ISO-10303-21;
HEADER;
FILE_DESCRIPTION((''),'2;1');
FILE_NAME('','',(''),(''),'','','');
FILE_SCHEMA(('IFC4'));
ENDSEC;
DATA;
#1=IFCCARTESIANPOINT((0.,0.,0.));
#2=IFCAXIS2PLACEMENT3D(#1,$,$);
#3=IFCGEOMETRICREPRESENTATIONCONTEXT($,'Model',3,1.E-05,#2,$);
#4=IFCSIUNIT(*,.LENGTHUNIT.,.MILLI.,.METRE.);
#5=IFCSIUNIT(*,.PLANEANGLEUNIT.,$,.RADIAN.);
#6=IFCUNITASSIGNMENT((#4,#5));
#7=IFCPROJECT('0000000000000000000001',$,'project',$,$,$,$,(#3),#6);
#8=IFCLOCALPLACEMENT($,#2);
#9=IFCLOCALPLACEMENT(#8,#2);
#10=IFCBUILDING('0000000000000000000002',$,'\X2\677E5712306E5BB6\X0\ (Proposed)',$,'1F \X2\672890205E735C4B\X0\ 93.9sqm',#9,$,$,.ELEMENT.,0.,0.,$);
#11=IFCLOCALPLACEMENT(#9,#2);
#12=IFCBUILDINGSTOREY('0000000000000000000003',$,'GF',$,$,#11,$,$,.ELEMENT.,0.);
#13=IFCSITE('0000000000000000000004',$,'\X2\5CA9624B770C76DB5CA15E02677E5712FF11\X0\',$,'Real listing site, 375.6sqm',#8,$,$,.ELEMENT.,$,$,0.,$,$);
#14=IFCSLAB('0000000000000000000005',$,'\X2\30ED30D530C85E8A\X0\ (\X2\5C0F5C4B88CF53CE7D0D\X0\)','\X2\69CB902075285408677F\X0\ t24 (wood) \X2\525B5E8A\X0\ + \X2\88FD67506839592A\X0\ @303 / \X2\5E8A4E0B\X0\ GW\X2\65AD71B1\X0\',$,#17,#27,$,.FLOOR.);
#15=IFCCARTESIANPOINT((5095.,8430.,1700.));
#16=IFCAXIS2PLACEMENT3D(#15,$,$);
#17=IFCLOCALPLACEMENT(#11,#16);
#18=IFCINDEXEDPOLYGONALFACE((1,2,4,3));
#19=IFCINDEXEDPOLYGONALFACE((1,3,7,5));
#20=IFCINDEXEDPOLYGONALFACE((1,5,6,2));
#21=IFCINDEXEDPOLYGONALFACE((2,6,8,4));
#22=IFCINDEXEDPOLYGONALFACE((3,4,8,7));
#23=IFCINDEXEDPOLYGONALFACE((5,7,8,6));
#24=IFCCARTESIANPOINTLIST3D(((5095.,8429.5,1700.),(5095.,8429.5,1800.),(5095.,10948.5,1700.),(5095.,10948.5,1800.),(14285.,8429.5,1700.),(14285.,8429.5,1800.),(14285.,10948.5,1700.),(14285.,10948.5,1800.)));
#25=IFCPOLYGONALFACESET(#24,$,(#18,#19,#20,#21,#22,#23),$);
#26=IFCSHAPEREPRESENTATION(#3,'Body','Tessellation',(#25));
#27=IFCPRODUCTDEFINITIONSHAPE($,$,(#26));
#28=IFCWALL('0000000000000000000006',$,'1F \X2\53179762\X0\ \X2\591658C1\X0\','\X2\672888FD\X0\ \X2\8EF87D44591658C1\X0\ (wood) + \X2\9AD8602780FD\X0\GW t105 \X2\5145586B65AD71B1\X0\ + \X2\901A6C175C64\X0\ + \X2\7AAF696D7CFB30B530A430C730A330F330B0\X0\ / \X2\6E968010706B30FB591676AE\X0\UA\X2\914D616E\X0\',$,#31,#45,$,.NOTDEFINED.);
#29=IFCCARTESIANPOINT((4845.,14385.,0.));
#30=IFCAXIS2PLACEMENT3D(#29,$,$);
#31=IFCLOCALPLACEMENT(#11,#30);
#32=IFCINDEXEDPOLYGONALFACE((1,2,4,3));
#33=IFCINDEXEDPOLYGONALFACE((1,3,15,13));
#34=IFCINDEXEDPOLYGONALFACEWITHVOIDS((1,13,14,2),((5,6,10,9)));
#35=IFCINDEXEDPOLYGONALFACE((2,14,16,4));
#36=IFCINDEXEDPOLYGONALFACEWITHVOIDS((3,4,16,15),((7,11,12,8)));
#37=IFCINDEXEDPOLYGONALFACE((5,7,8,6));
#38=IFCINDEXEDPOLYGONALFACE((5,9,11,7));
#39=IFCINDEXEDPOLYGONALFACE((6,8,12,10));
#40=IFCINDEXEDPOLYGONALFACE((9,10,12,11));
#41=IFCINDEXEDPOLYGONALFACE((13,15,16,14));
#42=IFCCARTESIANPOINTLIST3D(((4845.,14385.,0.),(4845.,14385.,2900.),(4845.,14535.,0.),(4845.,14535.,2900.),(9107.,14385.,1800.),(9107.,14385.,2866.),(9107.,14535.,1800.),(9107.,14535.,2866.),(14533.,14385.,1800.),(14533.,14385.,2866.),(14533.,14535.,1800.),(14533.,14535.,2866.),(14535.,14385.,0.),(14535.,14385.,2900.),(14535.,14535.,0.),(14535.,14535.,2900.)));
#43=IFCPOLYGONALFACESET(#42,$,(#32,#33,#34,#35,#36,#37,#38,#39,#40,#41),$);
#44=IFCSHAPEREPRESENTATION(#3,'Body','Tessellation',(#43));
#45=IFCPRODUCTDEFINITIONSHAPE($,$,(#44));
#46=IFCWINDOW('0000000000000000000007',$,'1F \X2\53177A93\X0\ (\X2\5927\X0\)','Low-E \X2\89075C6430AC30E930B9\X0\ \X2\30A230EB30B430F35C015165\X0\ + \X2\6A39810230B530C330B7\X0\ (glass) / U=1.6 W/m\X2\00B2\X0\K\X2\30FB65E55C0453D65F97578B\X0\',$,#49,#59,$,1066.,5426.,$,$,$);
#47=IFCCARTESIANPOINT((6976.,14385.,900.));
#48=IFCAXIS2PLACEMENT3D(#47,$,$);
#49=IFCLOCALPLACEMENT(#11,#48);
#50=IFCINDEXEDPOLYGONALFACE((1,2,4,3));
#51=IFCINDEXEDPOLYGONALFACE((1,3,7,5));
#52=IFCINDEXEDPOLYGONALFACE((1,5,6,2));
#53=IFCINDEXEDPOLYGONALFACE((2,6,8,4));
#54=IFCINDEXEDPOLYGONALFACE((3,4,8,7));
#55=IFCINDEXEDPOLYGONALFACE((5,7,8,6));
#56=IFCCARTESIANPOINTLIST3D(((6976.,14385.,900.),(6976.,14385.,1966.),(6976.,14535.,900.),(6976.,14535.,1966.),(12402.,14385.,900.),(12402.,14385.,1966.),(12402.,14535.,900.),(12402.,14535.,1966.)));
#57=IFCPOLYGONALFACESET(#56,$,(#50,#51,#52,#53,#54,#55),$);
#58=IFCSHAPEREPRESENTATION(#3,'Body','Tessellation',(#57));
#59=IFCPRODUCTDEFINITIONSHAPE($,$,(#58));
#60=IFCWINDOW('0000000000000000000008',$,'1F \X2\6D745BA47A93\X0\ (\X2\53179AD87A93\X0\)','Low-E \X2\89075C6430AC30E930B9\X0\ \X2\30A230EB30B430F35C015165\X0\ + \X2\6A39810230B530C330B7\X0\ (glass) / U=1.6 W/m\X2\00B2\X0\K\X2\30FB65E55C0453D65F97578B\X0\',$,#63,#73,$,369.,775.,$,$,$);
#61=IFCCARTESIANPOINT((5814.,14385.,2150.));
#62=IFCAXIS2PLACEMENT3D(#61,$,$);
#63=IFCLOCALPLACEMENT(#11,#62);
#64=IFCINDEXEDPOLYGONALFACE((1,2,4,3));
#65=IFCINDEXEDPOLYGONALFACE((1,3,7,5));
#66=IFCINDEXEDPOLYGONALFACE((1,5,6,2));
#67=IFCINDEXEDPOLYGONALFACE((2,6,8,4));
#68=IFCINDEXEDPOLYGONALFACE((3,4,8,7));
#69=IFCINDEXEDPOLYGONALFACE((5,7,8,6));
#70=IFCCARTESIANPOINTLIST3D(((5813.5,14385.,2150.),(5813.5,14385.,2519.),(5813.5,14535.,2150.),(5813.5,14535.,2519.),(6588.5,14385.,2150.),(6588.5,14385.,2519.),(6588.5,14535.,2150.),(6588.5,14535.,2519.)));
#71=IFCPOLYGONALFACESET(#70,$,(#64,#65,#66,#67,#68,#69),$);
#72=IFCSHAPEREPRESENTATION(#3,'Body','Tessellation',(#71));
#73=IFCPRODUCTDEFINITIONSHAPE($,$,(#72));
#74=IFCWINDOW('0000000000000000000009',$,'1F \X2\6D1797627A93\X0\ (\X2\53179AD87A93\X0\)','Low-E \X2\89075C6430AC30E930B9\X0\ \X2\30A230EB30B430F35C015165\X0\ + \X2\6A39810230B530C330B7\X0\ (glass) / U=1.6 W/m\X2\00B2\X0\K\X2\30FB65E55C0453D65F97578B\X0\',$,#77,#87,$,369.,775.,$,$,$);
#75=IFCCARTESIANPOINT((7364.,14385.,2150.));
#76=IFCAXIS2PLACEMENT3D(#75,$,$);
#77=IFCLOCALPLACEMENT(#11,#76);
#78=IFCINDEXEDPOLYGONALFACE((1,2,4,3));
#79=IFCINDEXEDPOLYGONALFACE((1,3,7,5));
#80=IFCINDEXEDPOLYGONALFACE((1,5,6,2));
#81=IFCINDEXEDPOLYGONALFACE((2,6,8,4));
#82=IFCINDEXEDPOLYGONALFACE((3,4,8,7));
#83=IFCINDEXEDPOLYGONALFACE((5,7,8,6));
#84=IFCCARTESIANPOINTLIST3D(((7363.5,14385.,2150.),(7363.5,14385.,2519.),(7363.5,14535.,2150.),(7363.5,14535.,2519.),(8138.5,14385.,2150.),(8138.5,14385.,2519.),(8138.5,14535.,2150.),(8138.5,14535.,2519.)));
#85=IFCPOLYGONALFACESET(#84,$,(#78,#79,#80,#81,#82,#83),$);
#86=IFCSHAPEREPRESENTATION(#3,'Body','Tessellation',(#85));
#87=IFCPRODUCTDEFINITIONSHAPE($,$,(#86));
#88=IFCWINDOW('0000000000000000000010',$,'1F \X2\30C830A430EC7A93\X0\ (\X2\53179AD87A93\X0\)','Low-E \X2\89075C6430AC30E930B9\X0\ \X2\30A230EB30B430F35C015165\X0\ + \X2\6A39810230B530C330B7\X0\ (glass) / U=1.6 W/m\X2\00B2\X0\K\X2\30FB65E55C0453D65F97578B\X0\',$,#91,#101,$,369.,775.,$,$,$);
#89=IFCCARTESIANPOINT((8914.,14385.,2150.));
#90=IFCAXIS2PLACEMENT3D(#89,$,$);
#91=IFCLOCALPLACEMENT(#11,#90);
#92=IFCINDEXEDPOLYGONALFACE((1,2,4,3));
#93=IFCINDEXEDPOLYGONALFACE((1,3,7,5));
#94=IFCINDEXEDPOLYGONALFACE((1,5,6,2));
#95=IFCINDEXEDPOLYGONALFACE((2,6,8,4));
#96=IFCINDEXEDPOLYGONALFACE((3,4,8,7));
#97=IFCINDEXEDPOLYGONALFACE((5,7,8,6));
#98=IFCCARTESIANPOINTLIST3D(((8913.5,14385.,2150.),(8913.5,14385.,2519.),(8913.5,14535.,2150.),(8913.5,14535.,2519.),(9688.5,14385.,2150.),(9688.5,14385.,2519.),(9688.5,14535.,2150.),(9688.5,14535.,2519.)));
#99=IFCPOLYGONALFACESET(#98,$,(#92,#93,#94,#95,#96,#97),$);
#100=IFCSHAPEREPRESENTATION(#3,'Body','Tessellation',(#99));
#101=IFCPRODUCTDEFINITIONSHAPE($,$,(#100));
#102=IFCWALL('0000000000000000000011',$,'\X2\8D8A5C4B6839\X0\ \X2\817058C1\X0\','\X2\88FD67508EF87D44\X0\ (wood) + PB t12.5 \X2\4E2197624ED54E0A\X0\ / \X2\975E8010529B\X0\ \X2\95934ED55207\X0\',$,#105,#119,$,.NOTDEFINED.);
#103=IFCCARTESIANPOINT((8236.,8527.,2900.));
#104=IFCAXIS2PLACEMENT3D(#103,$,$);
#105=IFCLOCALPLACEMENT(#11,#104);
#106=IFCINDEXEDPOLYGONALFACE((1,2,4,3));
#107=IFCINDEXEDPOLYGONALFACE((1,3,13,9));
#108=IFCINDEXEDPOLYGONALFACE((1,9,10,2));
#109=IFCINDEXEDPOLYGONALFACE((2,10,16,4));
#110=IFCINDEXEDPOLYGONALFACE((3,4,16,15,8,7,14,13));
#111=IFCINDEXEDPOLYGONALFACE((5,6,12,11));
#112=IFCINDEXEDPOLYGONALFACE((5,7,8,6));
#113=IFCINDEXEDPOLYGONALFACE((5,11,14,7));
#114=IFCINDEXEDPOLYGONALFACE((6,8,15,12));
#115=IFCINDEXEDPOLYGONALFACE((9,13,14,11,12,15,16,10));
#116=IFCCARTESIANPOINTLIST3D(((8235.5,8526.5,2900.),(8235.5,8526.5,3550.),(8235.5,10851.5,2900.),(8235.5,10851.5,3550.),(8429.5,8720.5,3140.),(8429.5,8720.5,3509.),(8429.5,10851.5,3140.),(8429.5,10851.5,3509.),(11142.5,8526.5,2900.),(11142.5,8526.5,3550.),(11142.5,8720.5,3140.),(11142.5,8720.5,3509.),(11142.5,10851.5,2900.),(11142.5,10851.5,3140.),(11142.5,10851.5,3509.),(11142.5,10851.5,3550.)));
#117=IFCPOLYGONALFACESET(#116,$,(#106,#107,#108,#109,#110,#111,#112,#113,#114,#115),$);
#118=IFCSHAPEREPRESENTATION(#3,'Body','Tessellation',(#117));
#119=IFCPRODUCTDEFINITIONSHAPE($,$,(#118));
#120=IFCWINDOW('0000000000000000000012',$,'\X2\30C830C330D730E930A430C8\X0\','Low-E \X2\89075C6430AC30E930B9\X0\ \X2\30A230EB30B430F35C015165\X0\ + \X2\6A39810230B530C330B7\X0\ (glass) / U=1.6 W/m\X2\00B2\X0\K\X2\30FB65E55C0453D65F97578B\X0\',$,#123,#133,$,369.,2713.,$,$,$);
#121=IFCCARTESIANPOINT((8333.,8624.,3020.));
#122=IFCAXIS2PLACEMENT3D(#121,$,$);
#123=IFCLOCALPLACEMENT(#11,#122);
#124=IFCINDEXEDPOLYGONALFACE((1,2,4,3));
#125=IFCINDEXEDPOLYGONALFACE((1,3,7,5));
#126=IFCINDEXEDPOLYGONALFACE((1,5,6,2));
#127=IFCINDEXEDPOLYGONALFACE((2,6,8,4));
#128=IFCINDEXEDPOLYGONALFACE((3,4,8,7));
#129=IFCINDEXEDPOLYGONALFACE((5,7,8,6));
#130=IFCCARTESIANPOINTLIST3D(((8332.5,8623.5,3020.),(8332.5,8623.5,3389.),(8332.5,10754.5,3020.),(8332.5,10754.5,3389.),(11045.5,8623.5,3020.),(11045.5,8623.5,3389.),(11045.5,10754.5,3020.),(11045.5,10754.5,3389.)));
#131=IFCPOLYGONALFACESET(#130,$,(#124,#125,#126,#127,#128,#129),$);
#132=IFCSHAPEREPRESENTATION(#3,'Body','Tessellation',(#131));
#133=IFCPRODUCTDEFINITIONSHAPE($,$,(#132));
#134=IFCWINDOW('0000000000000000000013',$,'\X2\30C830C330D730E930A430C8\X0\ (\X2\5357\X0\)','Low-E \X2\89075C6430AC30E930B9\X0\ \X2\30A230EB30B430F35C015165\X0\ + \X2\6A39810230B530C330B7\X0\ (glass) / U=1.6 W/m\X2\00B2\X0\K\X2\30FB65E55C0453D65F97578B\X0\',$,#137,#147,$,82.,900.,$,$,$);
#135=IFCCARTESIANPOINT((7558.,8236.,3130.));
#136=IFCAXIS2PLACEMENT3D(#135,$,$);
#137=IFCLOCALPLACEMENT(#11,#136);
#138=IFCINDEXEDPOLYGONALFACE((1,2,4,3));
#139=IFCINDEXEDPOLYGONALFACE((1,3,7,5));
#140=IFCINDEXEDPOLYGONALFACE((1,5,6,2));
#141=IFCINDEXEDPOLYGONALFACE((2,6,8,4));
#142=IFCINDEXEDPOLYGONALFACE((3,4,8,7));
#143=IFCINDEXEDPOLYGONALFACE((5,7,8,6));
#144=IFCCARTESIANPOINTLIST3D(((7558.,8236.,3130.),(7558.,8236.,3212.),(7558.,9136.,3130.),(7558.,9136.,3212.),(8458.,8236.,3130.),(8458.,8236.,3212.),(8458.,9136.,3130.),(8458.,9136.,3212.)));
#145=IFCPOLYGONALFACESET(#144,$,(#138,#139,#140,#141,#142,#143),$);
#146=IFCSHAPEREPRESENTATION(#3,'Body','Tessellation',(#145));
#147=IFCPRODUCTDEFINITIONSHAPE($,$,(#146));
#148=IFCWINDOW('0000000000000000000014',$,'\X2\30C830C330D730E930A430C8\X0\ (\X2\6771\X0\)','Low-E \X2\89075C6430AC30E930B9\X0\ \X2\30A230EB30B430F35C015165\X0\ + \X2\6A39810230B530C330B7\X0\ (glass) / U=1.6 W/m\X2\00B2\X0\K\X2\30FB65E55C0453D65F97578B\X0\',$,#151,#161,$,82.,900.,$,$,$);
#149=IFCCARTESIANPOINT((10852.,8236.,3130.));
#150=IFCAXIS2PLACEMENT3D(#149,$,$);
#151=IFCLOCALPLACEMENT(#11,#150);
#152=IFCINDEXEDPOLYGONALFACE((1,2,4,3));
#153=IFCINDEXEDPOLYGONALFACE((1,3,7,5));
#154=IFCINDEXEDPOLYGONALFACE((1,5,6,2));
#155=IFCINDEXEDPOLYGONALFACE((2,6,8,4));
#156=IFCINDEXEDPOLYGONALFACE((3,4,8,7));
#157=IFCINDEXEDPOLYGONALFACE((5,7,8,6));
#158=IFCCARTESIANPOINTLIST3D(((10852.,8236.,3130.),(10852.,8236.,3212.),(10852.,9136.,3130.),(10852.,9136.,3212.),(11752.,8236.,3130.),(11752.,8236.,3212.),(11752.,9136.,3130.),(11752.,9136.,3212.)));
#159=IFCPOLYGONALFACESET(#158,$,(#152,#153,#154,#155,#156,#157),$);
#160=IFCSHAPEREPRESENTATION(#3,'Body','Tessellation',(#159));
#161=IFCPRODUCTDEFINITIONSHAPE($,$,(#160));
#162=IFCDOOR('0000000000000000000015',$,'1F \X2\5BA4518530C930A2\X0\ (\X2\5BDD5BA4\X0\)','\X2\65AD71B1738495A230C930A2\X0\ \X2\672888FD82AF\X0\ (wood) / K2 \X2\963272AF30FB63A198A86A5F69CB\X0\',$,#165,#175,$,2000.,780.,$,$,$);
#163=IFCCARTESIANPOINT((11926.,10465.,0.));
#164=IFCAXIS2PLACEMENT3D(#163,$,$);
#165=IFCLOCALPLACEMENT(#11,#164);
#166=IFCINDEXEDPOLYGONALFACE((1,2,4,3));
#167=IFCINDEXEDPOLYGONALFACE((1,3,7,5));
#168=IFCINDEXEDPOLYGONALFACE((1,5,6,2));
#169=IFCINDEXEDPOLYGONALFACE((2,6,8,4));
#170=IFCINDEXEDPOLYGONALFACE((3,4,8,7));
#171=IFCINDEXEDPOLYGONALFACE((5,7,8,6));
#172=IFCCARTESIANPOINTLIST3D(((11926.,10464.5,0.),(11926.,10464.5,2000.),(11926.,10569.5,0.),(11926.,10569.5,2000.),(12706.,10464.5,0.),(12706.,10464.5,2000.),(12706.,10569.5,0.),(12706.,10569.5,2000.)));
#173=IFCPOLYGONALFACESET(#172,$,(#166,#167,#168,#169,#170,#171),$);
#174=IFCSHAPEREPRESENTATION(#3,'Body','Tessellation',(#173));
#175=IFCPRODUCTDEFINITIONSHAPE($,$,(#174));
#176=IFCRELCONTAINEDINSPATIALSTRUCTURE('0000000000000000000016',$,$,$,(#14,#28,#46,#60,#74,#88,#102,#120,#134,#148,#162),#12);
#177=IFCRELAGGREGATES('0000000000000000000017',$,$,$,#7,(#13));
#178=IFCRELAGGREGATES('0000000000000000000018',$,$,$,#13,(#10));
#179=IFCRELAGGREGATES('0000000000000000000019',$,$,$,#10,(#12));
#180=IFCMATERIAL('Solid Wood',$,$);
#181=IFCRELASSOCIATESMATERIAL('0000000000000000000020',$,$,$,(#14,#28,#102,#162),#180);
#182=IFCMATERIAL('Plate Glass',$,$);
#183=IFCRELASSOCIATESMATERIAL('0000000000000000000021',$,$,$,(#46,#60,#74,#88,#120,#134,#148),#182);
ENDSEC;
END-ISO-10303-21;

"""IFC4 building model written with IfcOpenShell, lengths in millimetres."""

from ifc_helpers import new_model, si_unit, frame, frame_2d, origin, place, context, project, spatial, rectangle, extrude, material, element, fill, save


model = new_model("IFC4")

# Units and contexts
model_context = context("Model", 3, precision=1e-05, world=origin())
ifc_project = project(units=[si_unit("LENGTHUNIT", "METRE", prefix="MILLI"), si_unit("PLANEANGLEUNIT", "RADIAN")], contexts=[model_context])

# Site, building, storey
site_placement = place(None, origin())
site = spatial("IfcSite", under=ifc_project, at=site_placement, Name="岩手県盛岡市松園１", ObjectType="Real listing site, 375.6sqm", CompositionType="ELEMENT", RefElevation=0.0)
building_placement = place(site_placement, origin())
building = spatial("IfcBuilding", under=site, at=building_placement, Name="松園の家 (Proposed)", ObjectType="1F 木造平屋 93.9sqm", CompositionType="ELEMENT", ElevationOfRefHeight=0.0, ElevationOfTerrain=0.0)
storey_placement = place(building_placement, origin())
storey = spatial("IfcBuildingStorey", under=building, at=storey_placement, Name="GF", CompositionType="ELEMENT", Elevation=0.0)

# Slab
ifc_material_1 = material(Name="Solid Wood")
slab_placement = place(storey_placement, frame((5095.0, 8430.0, 1700.0)))
element("IfcSlab", 1, at=slab_placement, inside=storey, material=ifc_material_1, Name="ロフト床 (小屋裏収納)", Description="構造用合板 t24 (wood) 剛床 + 製材根太 @303 / 床下 GW断熱", PredefinedType="FLOOR", context=model_context, shape_type="SweptSolid", body=[
    extrude(rectangle(XDim=9190.0, YDim=2519.0, at=frame_2d((4595.0, 1259.0))), frame((5095.0, 8430.0, 1700.0)), (0.0, 0.0, 1.0), 100.0),
])

# Wall, openings, windows
wall_1_placement = place(storey_placement, frame((4845.0, 14385.0, 0.0)))
wall_1 = element("IfcWall", 2, at=wall_1_placement, inside=storey, material=ifc_material_1, Name="1F 北面 外壁", Description="木製 軸組外壁 (wood) + 高性能GW t105 充填断熱 + 通気層 + 窯業系サイディング / 準耐火・外皮UA配慮", PredefinedType="NOTDEFINED", context=model_context, shape_type="SweptSolid", body=[
    extrude(rectangle(XDim=9690.0, YDim=150.0, at=frame_2d((4845.0, 75.0))), frame((4845.0, 14385.0, 0.0)), (0.0, 0.0, 1.0), 2900.0),
])
opening_1_placement = place(storey_placement, frame((6976.0, 14385.0, 900.0)))
opening_1 = element("IfcOpeningElement", 3, at=opening_1_placement, cuts=wall_1, PredefinedType="NOTDEFINED", context=model_context, shape_type="SweptSolid", body=[
    extrude(rectangle(XDim=5426.0, YDim=150.0, at=frame_2d((2713.0, 75.0))), frame((6976.0, 14385.0, 900.0)), (0.0, 0.0, 1.0), 1066.0),
])
opening_2_placement = place(storey_placement, frame((5814.0, 14385.0, 2150.0)))
opening_2 = element("IfcOpeningElement", 4, at=opening_2_placement, cuts=wall_1, PredefinedType="NOTDEFINED", context=model_context, shape_type="SweptSolid", body=[
    extrude(rectangle(XDim=775.0, YDim=150.0, at=frame_2d((387.0, 75.0))), frame((5814.0, 14385.0, 2150.0)), (0.0, 0.0, 1.0), 369.0),
])
opening_3_placement = place(storey_placement, frame((7364.0, 14385.0, 2150.0)))
opening_3 = element("IfcOpeningElement", 5, at=opening_3_placement, cuts=wall_1, PredefinedType="NOTDEFINED", context=model_context, shape_type="SweptSolid", body=[
    extrude(rectangle(XDim=775.0, YDim=150.0, at=frame_2d((387.0, 75.0))), frame((7364.0, 14385.0, 2150.0)), (0.0, 0.0, 1.0), 369.0),
])
opening_4_placement = place(storey_placement, frame((8914.0, 14385.0, 2150.0)))
opening_4 = element("IfcOpeningElement", 6, at=opening_4_placement, cuts=wall_1, PredefinedType="NOTDEFINED", context=model_context, shape_type="SweptSolid", body=[
    extrude(rectangle(XDim=775.0, YDim=150.0, at=frame_2d((387.0, 75.0))), frame((8914.0, 14385.0, 2150.0)), (0.0, 0.0, 1.0), 369.0),
])
ifc_material_2 = material(Name="Plate Glass")
window_1_placement = place(storey_placement, frame((6976.0, 14385.0, 900.0)))
window_1 = element("IfcWindow", 7, at=window_1_placement, inside=storey, material=ifc_material_2, Name="1F 北窓 (大)", Description="Low-E 複層ガラス アルゴン封入 + 樹脂サッシ (glass) / U=1.6 W/m²K・日射取得型", OverallHeight=1066.0, OverallWidth=5426.0, context=model_context, shape_type="SweptSolid", body=[
    extrude(rectangle(XDim=5426.0, YDim=150.0, at=frame_2d((2713.0, 75.0))), frame((6976.0, 14385.0, 900.0)), (0.0, 0.0, 1.0), 1066.0),
])
fill(opening_1, window_1)
window_2_placement = place(storey_placement, frame((5814.0, 14385.0, 2150.0)))
window_2 = element("IfcWindow", 8, at=window_2_placement, inside=storey, material=ifc_material_2, Name="1F 浴室窓 (北高窓)", Description="Low-E 複層ガラス アルゴン封入 + 樹脂サッシ (glass) / U=1.6 W/m²K・日射取得型", OverallHeight=369.0, OverallWidth=775.0, context=model_context, shape_type="SweptSolid", body=[
    extrude(rectangle(XDim=775.0, YDim=150.0, at=frame_2d((387.0, 75.0))), frame((5814.0, 14385.0, 2150.0)), (0.0, 0.0, 1.0), 369.0),
])
fill(opening_2, window_2)
window_3_placement = place(storey_placement, frame((7364.0, 14385.0, 2150.0)))
window_3 = element("IfcWindow", 9, at=window_3_placement, inside=storey, material=ifc_material_2, Name="1F 洗面窓 (北高窓)", Description="Low-E 複層ガラス アルゴン封入 + 樹脂サッシ (glass) / U=1.6 W/m²K・日射取得型", OverallHeight=369.0, OverallWidth=775.0, context=model_context, shape_type="SweptSolid", body=[
    extrude(rectangle(XDim=775.0, YDim=150.0, at=frame_2d((387.0, 75.0))), frame((7364.0, 14385.0, 2150.0)), (0.0, 0.0, 1.0), 369.0),
])
fill(opening_3, window_3)
window_4_placement = place(storey_placement, frame((8914.0, 14385.0, 2150.0)))
window_4 = element("IfcWindow", 10, at=window_4_placement, inside=storey, material=ifc_material_2, Name="1F トイレ窓 (北高窓)", Description="Low-E 複層ガラス アルゴン封入 + 樹脂サッシ (glass) / U=1.6 W/m²K・日射取得型", OverallHeight=369.0, OverallWidth=775.0, context=model_context, shape_type="SweptSolid", body=[
    extrude(rectangle(XDim=775.0, YDim=150.0, at=frame_2d((387.0, 75.0))), frame((8914.0, 14385.0, 2150.0)), (0.0, 0.0, 1.0), 369.0),
])
fill(opening_4, window_4)

# Wall, openings, windows
wall_2_placement = place(storey_placement, frame((8236.0, 8527.0, 2900.0)))
wall_2 = element("IfcWall", 11, at=wall_2_placement, inside=storey, material=ifc_material_1, Name="越屋根 腰壁", Description="製材軸組 (wood) + PB t12.5 両面仕上 / 非耐力 間仕切", PredefinedType="NOTDEFINED", context=model_context, shape_type="SweptSolid", body=[
    extrude(rectangle(XDim=2907.0, YDim=2325.0, at=frame_2d((1453.0, 1162.0))), frame((8236.0, 8527.0, 2900.0)), (0.0, 0.0, 1.0), 650.0),
])
opening_5_placement = place(storey_placement, frame((8333.0, 8624.0, 3020.0)))
opening_5 = element("IfcOpeningElement", 12, at=opening_5_placement, cuts=wall_2, PredefinedType="NOTDEFINED", context=model_context, shape_type="SweptSolid", body=[
    extrude(rectangle(XDim=2713.0, YDim=2131.0, at=frame_2d((1356.0, 1065.0))), frame((8333.0, 8624.0, 3020.0)), (0.0, 0.0, 1.0), 369.0),
])
opening_6_placement = place(storey_placement, frame((7558.0, 8236.0, 3130.0)))
opening_6 = element("IfcOpeningElement", 13, at=opening_6_placement, cuts=wall_2, PredefinedType="NOTDEFINED", context=model_context, shape_type="SweptSolid", body=[
    extrude(rectangle(XDim=900.0, YDim=900.0, at=frame_2d((450.0, 450.0))), frame((7558.0, 8236.0, 3130.0)), (0.0, 0.0, 1.0), 82.0),
])
opening_7_placement = place(storey_placement, frame((10852.0, 8236.0, 3130.0)))
opening_7 = element("IfcOpeningElement", 14, at=opening_7_placement, cuts=wall_2, PredefinedType="NOTDEFINED", context=model_context, shape_type="SweptSolid", body=[
    extrude(rectangle(XDim=900.0, YDim=900.0, at=frame_2d((450.0, 450.0))), frame((10852.0, 8236.0, 3130.0)), (0.0, 0.0, 1.0), 82.0),
])
window_5_placement = place(storey_placement, frame((8333.0, 8624.0, 3020.0)))
window_5 = element("IfcWindow", 15, at=window_5_placement, inside=storey, material=ifc_material_2, Name="トップライト", Description="Low-E 複層ガラス アルゴン封入 + 樹脂サッシ (glass) / U=1.6 W/m²K・日射取得型", OverallHeight=369.0, OverallWidth=2713.0, context=model_context, shape_type="SweptSolid", body=[
    extrude(rectangle(XDim=2713.0, YDim=2131.0, at=frame_2d((1356.0, 1065.0))), frame((8333.0, 8624.0, 3020.0)), (0.0, 0.0, 1.0), 369.0),
])
fill(opening_5, window_5)
window_6_placement = place(storey_placement, frame((7558.0, 8236.0, 3130.0)))
window_6 = element("IfcWindow", 16, at=window_6_placement, inside=storey, material=ifc_material_2, Name="トップライト (南)", Description="Low-E 複層ガラス アルゴン封入 + 樹脂サッシ (glass) / U=1.6 W/m²K・日射取得型", OverallHeight=82.0, OverallWidth=900.0, context=model_context, shape_type="SweptSolid", body=[
    extrude(rectangle(XDim=900.0, YDim=900.0, at=frame_2d((450.0, 450.0))), frame((7558.0, 8236.0, 3130.0)), (0.0, 0.0, 1.0), 82.0),
])
fill(opening_6, window_6)
window_7_placement = place(storey_placement, frame((10852.0, 8236.0, 3130.0)))
window_7 = element("IfcWindow", 17, at=window_7_placement, inside=storey, material=ifc_material_2, Name="トップライト (東)", Description="Low-E 複層ガラス アルゴン封入 + 樹脂サッシ (glass) / U=1.6 W/m²K・日射取得型", OverallHeight=82.0, OverallWidth=900.0, context=model_context, shape_type="SweptSolid", body=[
    extrude(rectangle(XDim=900.0, YDim=900.0, at=frame_2d((450.0, 450.0))), frame((10852.0, 8236.0, 3130.0)), (0.0, 0.0, 1.0), 82.0),
])
fill(opening_7, window_7)

# Door
door_1_placement = place(storey_placement, frame((11926.0, 10465.0, 0.0)))
element("IfcDoor", 18, at=door_1_placement, inside=storey, material=ifc_material_1, Name="1F 室内ドア (寝室)", Description="断熱玄関ドア 木製芯 (wood) / K2 防犯・採風機構", OverallHeight=2000.0, OverallWidth=780.0, context=model_context, shape_type="SweptSolid", body=[
    extrude(rectangle(XDim=780.0, YDim=105.0, at=frame_2d((390.0, 52.0))), frame((11926.0, 10465.0, 0.0)), (0.0, 0.0, 1.0), 2000.0),
])

save(model, "model.ifc")
